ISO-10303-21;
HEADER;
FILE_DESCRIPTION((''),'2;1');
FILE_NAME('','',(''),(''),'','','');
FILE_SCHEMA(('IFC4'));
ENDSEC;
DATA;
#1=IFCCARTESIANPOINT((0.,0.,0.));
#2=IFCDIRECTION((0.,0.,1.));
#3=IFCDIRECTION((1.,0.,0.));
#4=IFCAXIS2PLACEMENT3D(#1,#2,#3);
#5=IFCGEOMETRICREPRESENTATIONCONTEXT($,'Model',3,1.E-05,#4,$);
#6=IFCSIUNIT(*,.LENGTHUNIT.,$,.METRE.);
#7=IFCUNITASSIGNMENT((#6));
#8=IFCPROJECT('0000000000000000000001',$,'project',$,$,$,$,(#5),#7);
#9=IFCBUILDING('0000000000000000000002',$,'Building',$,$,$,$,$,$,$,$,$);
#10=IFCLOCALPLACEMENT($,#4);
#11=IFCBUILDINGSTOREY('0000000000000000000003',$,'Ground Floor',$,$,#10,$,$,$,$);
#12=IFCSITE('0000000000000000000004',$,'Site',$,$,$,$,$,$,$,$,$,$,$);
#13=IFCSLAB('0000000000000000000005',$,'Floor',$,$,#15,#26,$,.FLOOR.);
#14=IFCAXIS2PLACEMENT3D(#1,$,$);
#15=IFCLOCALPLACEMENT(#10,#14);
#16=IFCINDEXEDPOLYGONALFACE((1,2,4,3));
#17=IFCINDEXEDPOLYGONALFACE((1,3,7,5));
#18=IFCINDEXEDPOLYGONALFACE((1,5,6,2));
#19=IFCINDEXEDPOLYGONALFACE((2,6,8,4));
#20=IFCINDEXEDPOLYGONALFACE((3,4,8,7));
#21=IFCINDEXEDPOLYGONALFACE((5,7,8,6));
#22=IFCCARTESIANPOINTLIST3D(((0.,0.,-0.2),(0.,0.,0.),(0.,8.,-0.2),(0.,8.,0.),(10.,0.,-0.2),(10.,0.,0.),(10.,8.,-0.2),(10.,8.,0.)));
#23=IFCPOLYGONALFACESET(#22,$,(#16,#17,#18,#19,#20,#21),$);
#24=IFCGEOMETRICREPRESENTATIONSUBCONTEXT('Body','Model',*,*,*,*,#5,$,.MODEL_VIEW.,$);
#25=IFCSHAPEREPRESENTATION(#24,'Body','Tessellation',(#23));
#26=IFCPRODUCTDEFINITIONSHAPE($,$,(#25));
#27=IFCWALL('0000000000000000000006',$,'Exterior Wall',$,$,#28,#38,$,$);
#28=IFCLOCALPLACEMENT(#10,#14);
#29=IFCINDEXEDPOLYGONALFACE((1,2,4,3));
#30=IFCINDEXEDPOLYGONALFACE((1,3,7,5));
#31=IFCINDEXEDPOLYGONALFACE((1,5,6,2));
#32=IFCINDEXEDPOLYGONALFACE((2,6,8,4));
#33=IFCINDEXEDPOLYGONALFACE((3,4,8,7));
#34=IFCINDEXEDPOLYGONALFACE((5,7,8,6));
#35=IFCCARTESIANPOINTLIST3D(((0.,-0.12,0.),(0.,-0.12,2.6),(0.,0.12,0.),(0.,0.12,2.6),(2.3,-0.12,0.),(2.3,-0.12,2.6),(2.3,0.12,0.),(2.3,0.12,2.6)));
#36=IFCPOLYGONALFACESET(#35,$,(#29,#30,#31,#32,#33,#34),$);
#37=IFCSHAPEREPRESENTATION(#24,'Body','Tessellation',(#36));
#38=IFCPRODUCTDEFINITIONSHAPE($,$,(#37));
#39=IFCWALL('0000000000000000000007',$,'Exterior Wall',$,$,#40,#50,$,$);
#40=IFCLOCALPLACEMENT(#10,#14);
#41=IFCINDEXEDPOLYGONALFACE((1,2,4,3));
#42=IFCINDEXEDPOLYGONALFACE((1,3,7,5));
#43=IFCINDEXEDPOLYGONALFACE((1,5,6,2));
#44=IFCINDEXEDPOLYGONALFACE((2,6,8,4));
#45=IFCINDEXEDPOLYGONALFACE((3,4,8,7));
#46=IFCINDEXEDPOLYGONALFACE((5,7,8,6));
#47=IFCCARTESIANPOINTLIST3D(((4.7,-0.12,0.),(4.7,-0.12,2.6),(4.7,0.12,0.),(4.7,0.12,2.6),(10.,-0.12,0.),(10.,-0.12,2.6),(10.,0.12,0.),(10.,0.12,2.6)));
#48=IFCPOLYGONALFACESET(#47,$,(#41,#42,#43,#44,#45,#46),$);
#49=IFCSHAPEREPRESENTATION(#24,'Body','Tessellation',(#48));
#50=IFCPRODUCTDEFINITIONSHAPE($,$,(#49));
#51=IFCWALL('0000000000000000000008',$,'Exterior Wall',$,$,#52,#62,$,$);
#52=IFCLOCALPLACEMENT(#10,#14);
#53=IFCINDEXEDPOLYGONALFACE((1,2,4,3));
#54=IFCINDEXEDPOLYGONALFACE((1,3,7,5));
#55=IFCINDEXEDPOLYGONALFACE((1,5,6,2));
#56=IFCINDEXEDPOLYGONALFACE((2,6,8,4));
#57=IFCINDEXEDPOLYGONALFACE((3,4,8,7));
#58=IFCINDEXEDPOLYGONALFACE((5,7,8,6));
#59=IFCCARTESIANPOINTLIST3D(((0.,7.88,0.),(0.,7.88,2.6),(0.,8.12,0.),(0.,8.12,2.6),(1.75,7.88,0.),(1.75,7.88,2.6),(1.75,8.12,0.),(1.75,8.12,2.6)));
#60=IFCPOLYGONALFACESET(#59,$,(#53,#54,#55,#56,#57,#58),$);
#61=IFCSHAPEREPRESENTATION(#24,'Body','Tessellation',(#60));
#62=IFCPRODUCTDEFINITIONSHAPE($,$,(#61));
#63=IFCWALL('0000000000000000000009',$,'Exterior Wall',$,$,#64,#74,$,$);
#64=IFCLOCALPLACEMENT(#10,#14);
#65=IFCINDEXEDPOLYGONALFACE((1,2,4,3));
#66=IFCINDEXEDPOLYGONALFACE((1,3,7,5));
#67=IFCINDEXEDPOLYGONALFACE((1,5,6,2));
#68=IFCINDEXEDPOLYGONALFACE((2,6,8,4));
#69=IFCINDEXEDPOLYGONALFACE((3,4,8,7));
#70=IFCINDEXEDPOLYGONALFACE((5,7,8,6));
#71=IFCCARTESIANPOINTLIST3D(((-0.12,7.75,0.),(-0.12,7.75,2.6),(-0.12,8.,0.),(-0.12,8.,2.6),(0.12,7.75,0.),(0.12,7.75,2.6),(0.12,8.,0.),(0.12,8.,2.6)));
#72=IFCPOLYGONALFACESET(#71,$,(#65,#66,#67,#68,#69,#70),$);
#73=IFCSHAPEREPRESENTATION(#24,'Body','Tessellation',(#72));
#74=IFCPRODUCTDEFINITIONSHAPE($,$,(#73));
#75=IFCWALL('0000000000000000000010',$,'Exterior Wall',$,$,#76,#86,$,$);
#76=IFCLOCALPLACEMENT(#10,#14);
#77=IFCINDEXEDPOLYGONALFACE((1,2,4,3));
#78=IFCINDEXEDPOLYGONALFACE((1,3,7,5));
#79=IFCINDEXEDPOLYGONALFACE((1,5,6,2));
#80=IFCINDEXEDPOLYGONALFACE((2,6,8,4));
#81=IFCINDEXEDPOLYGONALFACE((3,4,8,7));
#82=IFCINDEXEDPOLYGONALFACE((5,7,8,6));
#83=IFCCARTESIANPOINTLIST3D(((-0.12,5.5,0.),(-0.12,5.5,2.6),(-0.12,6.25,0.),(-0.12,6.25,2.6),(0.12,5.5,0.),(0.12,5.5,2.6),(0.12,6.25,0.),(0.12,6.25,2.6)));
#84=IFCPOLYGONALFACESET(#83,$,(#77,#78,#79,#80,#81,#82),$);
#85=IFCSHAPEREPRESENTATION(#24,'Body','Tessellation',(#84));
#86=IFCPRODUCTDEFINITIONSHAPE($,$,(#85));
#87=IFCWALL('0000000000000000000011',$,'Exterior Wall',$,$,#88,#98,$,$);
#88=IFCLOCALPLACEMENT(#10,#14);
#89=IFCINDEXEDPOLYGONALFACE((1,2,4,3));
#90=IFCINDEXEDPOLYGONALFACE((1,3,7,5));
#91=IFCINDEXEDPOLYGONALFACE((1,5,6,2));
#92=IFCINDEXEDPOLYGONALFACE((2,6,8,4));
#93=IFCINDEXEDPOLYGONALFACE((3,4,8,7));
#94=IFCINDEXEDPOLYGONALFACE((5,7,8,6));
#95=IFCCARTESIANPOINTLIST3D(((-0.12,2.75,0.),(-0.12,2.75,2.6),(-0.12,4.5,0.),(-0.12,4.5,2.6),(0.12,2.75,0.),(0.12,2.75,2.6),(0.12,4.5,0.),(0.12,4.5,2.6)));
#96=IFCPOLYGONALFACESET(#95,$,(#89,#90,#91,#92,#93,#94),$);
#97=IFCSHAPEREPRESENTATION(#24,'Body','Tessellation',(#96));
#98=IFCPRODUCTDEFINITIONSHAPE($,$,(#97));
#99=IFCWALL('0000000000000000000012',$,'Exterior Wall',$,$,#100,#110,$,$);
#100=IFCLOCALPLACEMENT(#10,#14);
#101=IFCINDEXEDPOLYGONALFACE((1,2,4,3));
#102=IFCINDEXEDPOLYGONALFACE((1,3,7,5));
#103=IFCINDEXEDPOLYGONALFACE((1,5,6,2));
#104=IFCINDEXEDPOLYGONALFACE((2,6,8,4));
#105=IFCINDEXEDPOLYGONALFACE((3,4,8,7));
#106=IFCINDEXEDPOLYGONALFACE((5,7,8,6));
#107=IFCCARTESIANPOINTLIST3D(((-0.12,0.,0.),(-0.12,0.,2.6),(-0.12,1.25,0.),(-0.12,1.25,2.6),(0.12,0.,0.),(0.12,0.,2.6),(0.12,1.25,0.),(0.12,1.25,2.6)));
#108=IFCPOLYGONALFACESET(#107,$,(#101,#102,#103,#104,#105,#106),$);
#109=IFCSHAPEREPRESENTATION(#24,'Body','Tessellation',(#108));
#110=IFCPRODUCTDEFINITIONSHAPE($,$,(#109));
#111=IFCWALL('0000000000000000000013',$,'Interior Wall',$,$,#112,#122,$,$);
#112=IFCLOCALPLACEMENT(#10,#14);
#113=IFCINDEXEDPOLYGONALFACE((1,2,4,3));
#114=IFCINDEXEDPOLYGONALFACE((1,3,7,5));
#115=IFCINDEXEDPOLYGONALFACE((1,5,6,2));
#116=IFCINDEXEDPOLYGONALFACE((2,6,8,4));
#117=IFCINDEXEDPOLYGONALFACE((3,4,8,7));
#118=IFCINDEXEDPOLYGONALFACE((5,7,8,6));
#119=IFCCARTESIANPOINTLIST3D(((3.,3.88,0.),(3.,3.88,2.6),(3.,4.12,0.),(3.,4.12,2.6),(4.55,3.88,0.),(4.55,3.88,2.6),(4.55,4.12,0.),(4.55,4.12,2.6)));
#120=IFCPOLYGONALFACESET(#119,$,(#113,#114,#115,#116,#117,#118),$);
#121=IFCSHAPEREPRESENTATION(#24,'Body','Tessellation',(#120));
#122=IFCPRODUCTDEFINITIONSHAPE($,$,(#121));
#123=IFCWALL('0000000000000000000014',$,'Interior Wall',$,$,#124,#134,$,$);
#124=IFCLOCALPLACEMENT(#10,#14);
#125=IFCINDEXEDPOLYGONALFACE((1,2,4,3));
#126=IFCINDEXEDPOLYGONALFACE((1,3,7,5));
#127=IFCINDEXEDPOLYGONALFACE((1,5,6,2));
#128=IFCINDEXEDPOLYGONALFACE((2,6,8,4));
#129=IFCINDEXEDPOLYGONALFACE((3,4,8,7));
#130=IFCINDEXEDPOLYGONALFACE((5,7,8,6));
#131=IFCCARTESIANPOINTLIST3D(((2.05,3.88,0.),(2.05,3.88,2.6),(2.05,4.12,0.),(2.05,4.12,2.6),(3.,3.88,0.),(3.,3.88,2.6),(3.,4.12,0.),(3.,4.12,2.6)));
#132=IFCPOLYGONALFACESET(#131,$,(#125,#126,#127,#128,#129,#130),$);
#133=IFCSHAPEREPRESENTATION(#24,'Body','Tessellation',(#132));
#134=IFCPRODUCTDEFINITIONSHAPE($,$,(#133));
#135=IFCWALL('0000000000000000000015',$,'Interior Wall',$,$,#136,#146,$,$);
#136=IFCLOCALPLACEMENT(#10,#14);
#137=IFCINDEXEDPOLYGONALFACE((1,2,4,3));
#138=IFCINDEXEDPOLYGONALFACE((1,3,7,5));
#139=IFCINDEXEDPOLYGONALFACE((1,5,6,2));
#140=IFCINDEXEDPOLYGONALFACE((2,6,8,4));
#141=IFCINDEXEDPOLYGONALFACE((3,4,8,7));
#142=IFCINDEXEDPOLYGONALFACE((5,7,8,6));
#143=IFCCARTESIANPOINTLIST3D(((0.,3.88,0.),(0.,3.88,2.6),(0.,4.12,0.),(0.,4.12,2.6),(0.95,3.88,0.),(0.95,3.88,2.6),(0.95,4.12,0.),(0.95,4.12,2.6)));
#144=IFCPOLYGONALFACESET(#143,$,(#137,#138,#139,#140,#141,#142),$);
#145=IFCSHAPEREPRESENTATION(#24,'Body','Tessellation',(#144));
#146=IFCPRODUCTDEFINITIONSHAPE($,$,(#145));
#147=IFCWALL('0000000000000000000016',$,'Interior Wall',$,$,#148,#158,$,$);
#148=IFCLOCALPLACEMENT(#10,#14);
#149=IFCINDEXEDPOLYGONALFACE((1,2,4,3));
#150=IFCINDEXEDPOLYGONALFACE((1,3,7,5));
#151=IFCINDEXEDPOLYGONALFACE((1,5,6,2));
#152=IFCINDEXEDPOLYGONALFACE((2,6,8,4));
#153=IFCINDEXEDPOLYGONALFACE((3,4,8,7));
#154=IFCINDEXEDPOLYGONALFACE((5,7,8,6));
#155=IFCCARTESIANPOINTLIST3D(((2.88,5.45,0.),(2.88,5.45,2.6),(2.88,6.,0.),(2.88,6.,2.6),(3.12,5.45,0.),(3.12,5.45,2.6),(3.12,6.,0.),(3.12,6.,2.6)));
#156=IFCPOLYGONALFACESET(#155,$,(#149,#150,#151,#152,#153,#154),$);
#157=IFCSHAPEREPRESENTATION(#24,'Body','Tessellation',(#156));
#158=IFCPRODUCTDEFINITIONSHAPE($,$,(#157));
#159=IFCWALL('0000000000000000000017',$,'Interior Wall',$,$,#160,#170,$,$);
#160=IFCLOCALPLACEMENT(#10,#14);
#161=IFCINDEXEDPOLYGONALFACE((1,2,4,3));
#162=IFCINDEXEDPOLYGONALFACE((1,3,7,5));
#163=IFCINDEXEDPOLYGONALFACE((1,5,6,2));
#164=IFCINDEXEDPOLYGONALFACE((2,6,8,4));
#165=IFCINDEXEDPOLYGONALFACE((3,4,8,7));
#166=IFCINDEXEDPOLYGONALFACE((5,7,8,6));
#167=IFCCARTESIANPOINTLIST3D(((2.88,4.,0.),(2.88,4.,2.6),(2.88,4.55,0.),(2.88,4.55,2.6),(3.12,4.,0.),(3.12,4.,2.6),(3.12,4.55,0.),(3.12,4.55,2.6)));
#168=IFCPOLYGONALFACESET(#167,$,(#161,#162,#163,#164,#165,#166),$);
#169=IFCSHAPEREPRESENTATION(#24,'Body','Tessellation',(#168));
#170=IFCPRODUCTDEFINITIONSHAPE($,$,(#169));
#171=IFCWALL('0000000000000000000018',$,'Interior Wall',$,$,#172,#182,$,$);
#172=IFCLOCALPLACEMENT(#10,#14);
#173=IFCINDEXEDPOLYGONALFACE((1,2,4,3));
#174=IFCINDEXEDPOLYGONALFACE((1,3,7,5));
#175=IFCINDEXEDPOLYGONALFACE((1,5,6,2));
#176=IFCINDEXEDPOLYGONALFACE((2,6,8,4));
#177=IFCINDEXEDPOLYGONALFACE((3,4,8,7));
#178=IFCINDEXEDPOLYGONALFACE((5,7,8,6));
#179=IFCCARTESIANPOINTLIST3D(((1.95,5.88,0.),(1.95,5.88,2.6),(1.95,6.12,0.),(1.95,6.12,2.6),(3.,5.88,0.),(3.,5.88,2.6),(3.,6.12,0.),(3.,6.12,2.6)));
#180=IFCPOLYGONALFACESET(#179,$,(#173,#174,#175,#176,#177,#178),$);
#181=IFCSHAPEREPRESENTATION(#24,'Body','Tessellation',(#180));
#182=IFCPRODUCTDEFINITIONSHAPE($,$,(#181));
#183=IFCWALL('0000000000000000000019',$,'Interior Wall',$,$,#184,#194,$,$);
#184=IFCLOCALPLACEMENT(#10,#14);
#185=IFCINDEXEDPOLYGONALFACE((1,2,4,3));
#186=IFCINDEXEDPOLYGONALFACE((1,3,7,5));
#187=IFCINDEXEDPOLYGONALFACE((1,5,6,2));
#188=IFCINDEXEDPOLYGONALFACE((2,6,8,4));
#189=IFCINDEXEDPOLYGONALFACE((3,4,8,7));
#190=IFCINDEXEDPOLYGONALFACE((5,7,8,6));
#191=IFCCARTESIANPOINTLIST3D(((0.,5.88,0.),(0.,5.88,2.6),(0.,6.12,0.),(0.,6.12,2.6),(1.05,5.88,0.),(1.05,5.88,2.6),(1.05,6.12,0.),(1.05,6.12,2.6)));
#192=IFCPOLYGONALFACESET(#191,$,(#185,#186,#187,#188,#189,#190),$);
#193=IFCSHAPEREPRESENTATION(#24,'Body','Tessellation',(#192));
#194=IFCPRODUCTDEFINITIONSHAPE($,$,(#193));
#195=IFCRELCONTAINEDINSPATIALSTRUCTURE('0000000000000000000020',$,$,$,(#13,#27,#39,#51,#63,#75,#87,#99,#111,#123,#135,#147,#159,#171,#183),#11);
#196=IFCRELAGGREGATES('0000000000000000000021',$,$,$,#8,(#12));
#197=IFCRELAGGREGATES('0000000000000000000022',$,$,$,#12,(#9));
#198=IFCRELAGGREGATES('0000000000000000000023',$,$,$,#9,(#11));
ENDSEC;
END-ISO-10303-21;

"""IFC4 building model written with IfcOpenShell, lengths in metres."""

from ifc_helpers import new_model, si_unit, frame, origin_with_axes, place, context, subcontext, project, spatial, indexed_curve, outline, extrude, element, save


model = new_model("IFC4")

# Units and contexts
model_context = context("Model", 3, precision=1e-05, world=origin_with_axes())
body_context = subcontext(model_context, "Body", "Model", "MODEL_VIEW")
ifc_project = project(units=[si_unit("LENGTHUNIT", "METRE")], contexts=[model_context])

# Site, building, storey
site = spatial("IfcSite", under=ifc_project, Name="Site")
building = spatial("IfcBuilding", under=site, Name="Building")
storey_placement = place(None, origin_with_axes())
storey = spatial("IfcBuildingStorey", under=building, at=storey_placement, Name="Ground Floor")

# Slab
slab_placement = place(storey_placement, frame((0.0, 0.0, -0.2), z_axis=(0.0, 0.0, 1.0), x_axis=(1.0, 0.0, 0.0)))
element("IfcSlab", 1, at=slab_placement, inside=storey, Name="Floor", PredefinedType="FLOOR", context=body_context, shape_type="SweptSolid", body=[
    extrude(outline(indexed_curve([(0.0, 0.0), (10.0, 0.0), (10.0, 8.0), (0.0, 8.0)])), None, (0.0, 0.0, 1.0), 0.2),
])

# Walls
wall_1_placement = place(storey_placement, origin_with_axes())
element("IfcWall", 2, at=wall_1_placement, inside=storey, Name="Exterior Wall", context=body_context, shape_type="SweptSolid", body=[
    extrude(outline(indexed_curve([(0.0, 0.0), (0.0, 0.24), (2.3, 0.24), (2.3, 0.0), (0.0, 0.0)], self_intersect=False)), frame((0.0, -0.12, 0.0), z_axis=(0.0, 0.0, 1.0), x_axis=(1.0, 0.0, 0.0)), (0.0, 0.0, 1.0), 2.6),
])
wall_2_placement = place(storey_placement, frame((4.7, 0.0, 0.0), z_axis=(0.0, 0.0, 1.0), x_axis=(1.0, 0.0, 0.0)))
element("IfcWall", 3, at=wall_2_placement, inside=storey, Name="Exterior Wall", context=body_context, shape_type="SweptSolid", body=[
    extrude(outline(indexed_curve([(0.0, 0.0), (0.0, 0.24), (5.3, 0.24), (5.3, 0.0), (0.0, 0.0)], self_intersect=False)), frame((0.0, -0.12, 0.0), z_axis=(0.0, 0.0, 1.0), x_axis=(1.0, 0.0, 0.0)), (0.0, 0.0, 1.0), 2.6),
])
wall_3_placement = place(storey_placement, frame((1.75, 8.0, 0.0), z_axis=(0.0, 0.0, 1.0), x_axis=(-1.0, 0.0, 0.0)))
element("IfcWall", 4, at=wall_3_placement, inside=storey, Name="Exterior Wall", context=body_context, shape_type="SweptSolid", body=[
    extrude(outline(indexed_curve([(0.0, 0.0), (0.0, 0.24), (1.75, 0.24), (1.75, 0.0), (0.0, 0.0)], self_intersect=False)), frame((0.0, -0.12, 0.0), z_axis=(0.0, 0.0, 1.0), x_axis=(1.0, 0.0, 0.0)), (0.0, 0.0, 1.0), 2.6),
])
wall_4_placement = place(storey_placement, frame((0.0, 8.0, 0.0), z_axis=(0.0, 0.0, 1.0), x_axis=(0.0, -1.0, 0.0)))
element("IfcWall", 5, at=wall_4_placement, inside=storey, Name="Exterior Wall", context=body_context, shape_type="SweptSolid", body=[
    extrude(outline(indexed_curve([(0.0, 0.0), (0.0, 0.24), (0.25, 0.24), (0.25, 0.0), (0.0, 0.0)], self_intersect=False)), frame((0.0, -0.12, 0.0), z_axis=(0.0, 0.0, 1.0), x_axis=(1.0, 0.0, 0.0)), (0.0, 0.0, 1.0), 2.6),
])
wall_5_placement = place(storey_placement, frame((0.0, 6.25, 0.0), z_axis=(0.0, 0.0, 1.0), x_axis=(0.0, -1.0, 0.0)))
element("IfcWall", 6, at=wall_5_placement, inside=storey, Name="Exterior Wall", context=body_context, shape_type="SweptSolid", body=[
    extrude(outline(indexed_curve([(0.0, 0.0), (0.0, 0.24), (0.75, 0.24), (0.75, 0.0), (0.0, 0.0)], self_intersect=False)), frame((0.0, -0.12, 0.0), z_axis=(0.0, 0.0, 1.0), x_axis=(1.0, 0.0, 0.0)), (0.0, 0.0, 1.0), 2.6),
])
wall_6_placement = place(storey_placement, frame((0.0, 4.5, 0.0), z_axis=(0.0, 0.0, 1.0), x_axis=(0.0, -1.0, 0.0)))
element("IfcWall", 7, at=wall_6_placement, inside=storey, Name="Exterior Wall", context=body_context, shape_type="SweptSolid", body=[
    extrude(outline(indexed_curve([(0.0, 0.0), (0.0, 0.24), (1.75, 0.24), (1.75, 0.0), (0.0, 0.0)], self_intersect=False)), frame((0.0, -0.12, 0.0), z_axis=(0.0, 0.0, 1.0), x_axis=(1.0, 0.0, 0.0)), (0.0, 0.0, 1.0), 2.6),
])
wall_7_placement = place(storey_placement, frame((0.0, 1.25, 0.0), z_axis=(0.0, 0.0, 1.0), x_axis=(0.0, -1.0, 0.0)))
element("IfcWall", 8, at=wall_7_placement, inside=storey, Name="Exterior Wall", context=body_context, shape_type="SweptSolid", body=[
    extrude(outline(indexed_curve([(0.0, 0.0), (0.0, 0.24), (1.25, 0.24), (1.25, 0.0), (0.0, 0.0)], self_intersect=False)), frame((0.0, -0.12, 0.0), z_axis=(0.0, 0.0, 1.0), x_axis=(1.0, 0.0, 0.0)), (0.0, 0.0, 1.0), 2.6),
])
wall_8_placement = place(storey_placement, frame((4.55, 4.0, 0.0), z_axis=(0.0, 0.0, 1.0), x_axis=(-1.0, 0.0, 0.0)))
element("IfcWall", 9, at=wall_8_placement, inside=storey, Name="Interior Wall", context=body_context, shape_type="SweptSolid", body=[
    extrude(outline(indexed_curve([(0.0, 0.0), (0.0, 0.24), (1.55, 0.24), (1.55, 0.0), (0.0, 0.0)], self_intersect=False)), frame((0.0, -0.12, 0.0), z_axis=(0.0, 0.0, 1.0), x_axis=(1.0, 0.0, 0.0)), (0.0, 0.0, 1.0), 2.6),
])
for number, where, z_axis, x_axis, name in (
    (10, (3.0, 4.0, 0.0), (0.0, 0.0, 1.0), (-1.0, 0.0, 0.0), "Interior Wall"),
    (11, (0.95, 4.0, 0.0), (0.0, 0.0, 1.0), (-1.0, 0.0, 0.0), "Interior Wall"),
):
    element("IfcWall", number, at=place(storey_placement, frame(where, z_axis=z_axis, x_axis=x_axis)), inside=storey, Name=name, context=body_context, shape_type="SweptSolid", body=[
        extrude(outline(indexed_curve([(0.0, 0.0), (0.0, 0.24), (0.95, 0.24), (0.95, 0.0), (0.0, 0.0)], self_intersect=False)), frame((0.0, -0.12, 0.0), z_axis=(0.0, 0.0, 1.0), x_axis=(1.0, 0.0, 0.0)), (0.0, 0.0, 1.0), 2.6),
    ])
for number, where, z_axis, x_axis, name in (
    (12, (3.0, 6.0, 0.0), (0.0, 0.0, 1.0), (0.0, -1.0, 0.0), "Interior Wall"),
    (13, (3.0, 4.55, 0.0), (0.0, 0.0, 1.0), (0.0, -1.0, 0.0), "Interior Wall"),
):
    element("IfcWall", number, at=place(storey_placement, frame(where, z_axis=z_axis, x_axis=x_axis)), inside=storey, Name=name, context=body_context, shape_type="SweptSolid", body=[
        extrude(outline(indexed_curve([(0.0, 0.0), (0.0, 0.24), (0.55, 0.24), (0.55, 0.0), (0.0, 0.0)], self_intersect=False)), frame((0.0, -0.12, 0.0), z_axis=(0.0, 0.0, 1.0), x_axis=(1.0, 0.0, 0.0)), (0.0, 0.0, 1.0), 2.6),
    ])
for number, where, z_axis, x_axis, name in (
    (14, (3.0, 6.0, 0.0), (0.0, 0.0, 1.0), (-1.0, 0.0, 0.0), "Interior Wall"),
    (15, (1.05, 6.0, 0.0), (0.0, 0.0, 1.0), (-1.0, 0.0, 0.0), "Interior Wall"),
):
    element("IfcWall", number, at=place(storey_placement, frame(where, z_axis=z_axis, x_axis=x_axis)), inside=storey, Name=name, context=body_context, shape_type="SweptSolid", body=[
        extrude(outline(indexed_curve([(0.0, 0.0), (0.0, 0.24), (1.05, 0.24), (1.05, 0.0), (0.0, 0.0)], self_intersect=False)), frame((0.0, -0.12, 0.0), z_axis=(0.0, 0.0, 1.0), x_axis=(1.0, 0.0, 0.0)), (0.0, 0.0, 1.0), 2.6),
    ])

save(model, "model.ifc")
